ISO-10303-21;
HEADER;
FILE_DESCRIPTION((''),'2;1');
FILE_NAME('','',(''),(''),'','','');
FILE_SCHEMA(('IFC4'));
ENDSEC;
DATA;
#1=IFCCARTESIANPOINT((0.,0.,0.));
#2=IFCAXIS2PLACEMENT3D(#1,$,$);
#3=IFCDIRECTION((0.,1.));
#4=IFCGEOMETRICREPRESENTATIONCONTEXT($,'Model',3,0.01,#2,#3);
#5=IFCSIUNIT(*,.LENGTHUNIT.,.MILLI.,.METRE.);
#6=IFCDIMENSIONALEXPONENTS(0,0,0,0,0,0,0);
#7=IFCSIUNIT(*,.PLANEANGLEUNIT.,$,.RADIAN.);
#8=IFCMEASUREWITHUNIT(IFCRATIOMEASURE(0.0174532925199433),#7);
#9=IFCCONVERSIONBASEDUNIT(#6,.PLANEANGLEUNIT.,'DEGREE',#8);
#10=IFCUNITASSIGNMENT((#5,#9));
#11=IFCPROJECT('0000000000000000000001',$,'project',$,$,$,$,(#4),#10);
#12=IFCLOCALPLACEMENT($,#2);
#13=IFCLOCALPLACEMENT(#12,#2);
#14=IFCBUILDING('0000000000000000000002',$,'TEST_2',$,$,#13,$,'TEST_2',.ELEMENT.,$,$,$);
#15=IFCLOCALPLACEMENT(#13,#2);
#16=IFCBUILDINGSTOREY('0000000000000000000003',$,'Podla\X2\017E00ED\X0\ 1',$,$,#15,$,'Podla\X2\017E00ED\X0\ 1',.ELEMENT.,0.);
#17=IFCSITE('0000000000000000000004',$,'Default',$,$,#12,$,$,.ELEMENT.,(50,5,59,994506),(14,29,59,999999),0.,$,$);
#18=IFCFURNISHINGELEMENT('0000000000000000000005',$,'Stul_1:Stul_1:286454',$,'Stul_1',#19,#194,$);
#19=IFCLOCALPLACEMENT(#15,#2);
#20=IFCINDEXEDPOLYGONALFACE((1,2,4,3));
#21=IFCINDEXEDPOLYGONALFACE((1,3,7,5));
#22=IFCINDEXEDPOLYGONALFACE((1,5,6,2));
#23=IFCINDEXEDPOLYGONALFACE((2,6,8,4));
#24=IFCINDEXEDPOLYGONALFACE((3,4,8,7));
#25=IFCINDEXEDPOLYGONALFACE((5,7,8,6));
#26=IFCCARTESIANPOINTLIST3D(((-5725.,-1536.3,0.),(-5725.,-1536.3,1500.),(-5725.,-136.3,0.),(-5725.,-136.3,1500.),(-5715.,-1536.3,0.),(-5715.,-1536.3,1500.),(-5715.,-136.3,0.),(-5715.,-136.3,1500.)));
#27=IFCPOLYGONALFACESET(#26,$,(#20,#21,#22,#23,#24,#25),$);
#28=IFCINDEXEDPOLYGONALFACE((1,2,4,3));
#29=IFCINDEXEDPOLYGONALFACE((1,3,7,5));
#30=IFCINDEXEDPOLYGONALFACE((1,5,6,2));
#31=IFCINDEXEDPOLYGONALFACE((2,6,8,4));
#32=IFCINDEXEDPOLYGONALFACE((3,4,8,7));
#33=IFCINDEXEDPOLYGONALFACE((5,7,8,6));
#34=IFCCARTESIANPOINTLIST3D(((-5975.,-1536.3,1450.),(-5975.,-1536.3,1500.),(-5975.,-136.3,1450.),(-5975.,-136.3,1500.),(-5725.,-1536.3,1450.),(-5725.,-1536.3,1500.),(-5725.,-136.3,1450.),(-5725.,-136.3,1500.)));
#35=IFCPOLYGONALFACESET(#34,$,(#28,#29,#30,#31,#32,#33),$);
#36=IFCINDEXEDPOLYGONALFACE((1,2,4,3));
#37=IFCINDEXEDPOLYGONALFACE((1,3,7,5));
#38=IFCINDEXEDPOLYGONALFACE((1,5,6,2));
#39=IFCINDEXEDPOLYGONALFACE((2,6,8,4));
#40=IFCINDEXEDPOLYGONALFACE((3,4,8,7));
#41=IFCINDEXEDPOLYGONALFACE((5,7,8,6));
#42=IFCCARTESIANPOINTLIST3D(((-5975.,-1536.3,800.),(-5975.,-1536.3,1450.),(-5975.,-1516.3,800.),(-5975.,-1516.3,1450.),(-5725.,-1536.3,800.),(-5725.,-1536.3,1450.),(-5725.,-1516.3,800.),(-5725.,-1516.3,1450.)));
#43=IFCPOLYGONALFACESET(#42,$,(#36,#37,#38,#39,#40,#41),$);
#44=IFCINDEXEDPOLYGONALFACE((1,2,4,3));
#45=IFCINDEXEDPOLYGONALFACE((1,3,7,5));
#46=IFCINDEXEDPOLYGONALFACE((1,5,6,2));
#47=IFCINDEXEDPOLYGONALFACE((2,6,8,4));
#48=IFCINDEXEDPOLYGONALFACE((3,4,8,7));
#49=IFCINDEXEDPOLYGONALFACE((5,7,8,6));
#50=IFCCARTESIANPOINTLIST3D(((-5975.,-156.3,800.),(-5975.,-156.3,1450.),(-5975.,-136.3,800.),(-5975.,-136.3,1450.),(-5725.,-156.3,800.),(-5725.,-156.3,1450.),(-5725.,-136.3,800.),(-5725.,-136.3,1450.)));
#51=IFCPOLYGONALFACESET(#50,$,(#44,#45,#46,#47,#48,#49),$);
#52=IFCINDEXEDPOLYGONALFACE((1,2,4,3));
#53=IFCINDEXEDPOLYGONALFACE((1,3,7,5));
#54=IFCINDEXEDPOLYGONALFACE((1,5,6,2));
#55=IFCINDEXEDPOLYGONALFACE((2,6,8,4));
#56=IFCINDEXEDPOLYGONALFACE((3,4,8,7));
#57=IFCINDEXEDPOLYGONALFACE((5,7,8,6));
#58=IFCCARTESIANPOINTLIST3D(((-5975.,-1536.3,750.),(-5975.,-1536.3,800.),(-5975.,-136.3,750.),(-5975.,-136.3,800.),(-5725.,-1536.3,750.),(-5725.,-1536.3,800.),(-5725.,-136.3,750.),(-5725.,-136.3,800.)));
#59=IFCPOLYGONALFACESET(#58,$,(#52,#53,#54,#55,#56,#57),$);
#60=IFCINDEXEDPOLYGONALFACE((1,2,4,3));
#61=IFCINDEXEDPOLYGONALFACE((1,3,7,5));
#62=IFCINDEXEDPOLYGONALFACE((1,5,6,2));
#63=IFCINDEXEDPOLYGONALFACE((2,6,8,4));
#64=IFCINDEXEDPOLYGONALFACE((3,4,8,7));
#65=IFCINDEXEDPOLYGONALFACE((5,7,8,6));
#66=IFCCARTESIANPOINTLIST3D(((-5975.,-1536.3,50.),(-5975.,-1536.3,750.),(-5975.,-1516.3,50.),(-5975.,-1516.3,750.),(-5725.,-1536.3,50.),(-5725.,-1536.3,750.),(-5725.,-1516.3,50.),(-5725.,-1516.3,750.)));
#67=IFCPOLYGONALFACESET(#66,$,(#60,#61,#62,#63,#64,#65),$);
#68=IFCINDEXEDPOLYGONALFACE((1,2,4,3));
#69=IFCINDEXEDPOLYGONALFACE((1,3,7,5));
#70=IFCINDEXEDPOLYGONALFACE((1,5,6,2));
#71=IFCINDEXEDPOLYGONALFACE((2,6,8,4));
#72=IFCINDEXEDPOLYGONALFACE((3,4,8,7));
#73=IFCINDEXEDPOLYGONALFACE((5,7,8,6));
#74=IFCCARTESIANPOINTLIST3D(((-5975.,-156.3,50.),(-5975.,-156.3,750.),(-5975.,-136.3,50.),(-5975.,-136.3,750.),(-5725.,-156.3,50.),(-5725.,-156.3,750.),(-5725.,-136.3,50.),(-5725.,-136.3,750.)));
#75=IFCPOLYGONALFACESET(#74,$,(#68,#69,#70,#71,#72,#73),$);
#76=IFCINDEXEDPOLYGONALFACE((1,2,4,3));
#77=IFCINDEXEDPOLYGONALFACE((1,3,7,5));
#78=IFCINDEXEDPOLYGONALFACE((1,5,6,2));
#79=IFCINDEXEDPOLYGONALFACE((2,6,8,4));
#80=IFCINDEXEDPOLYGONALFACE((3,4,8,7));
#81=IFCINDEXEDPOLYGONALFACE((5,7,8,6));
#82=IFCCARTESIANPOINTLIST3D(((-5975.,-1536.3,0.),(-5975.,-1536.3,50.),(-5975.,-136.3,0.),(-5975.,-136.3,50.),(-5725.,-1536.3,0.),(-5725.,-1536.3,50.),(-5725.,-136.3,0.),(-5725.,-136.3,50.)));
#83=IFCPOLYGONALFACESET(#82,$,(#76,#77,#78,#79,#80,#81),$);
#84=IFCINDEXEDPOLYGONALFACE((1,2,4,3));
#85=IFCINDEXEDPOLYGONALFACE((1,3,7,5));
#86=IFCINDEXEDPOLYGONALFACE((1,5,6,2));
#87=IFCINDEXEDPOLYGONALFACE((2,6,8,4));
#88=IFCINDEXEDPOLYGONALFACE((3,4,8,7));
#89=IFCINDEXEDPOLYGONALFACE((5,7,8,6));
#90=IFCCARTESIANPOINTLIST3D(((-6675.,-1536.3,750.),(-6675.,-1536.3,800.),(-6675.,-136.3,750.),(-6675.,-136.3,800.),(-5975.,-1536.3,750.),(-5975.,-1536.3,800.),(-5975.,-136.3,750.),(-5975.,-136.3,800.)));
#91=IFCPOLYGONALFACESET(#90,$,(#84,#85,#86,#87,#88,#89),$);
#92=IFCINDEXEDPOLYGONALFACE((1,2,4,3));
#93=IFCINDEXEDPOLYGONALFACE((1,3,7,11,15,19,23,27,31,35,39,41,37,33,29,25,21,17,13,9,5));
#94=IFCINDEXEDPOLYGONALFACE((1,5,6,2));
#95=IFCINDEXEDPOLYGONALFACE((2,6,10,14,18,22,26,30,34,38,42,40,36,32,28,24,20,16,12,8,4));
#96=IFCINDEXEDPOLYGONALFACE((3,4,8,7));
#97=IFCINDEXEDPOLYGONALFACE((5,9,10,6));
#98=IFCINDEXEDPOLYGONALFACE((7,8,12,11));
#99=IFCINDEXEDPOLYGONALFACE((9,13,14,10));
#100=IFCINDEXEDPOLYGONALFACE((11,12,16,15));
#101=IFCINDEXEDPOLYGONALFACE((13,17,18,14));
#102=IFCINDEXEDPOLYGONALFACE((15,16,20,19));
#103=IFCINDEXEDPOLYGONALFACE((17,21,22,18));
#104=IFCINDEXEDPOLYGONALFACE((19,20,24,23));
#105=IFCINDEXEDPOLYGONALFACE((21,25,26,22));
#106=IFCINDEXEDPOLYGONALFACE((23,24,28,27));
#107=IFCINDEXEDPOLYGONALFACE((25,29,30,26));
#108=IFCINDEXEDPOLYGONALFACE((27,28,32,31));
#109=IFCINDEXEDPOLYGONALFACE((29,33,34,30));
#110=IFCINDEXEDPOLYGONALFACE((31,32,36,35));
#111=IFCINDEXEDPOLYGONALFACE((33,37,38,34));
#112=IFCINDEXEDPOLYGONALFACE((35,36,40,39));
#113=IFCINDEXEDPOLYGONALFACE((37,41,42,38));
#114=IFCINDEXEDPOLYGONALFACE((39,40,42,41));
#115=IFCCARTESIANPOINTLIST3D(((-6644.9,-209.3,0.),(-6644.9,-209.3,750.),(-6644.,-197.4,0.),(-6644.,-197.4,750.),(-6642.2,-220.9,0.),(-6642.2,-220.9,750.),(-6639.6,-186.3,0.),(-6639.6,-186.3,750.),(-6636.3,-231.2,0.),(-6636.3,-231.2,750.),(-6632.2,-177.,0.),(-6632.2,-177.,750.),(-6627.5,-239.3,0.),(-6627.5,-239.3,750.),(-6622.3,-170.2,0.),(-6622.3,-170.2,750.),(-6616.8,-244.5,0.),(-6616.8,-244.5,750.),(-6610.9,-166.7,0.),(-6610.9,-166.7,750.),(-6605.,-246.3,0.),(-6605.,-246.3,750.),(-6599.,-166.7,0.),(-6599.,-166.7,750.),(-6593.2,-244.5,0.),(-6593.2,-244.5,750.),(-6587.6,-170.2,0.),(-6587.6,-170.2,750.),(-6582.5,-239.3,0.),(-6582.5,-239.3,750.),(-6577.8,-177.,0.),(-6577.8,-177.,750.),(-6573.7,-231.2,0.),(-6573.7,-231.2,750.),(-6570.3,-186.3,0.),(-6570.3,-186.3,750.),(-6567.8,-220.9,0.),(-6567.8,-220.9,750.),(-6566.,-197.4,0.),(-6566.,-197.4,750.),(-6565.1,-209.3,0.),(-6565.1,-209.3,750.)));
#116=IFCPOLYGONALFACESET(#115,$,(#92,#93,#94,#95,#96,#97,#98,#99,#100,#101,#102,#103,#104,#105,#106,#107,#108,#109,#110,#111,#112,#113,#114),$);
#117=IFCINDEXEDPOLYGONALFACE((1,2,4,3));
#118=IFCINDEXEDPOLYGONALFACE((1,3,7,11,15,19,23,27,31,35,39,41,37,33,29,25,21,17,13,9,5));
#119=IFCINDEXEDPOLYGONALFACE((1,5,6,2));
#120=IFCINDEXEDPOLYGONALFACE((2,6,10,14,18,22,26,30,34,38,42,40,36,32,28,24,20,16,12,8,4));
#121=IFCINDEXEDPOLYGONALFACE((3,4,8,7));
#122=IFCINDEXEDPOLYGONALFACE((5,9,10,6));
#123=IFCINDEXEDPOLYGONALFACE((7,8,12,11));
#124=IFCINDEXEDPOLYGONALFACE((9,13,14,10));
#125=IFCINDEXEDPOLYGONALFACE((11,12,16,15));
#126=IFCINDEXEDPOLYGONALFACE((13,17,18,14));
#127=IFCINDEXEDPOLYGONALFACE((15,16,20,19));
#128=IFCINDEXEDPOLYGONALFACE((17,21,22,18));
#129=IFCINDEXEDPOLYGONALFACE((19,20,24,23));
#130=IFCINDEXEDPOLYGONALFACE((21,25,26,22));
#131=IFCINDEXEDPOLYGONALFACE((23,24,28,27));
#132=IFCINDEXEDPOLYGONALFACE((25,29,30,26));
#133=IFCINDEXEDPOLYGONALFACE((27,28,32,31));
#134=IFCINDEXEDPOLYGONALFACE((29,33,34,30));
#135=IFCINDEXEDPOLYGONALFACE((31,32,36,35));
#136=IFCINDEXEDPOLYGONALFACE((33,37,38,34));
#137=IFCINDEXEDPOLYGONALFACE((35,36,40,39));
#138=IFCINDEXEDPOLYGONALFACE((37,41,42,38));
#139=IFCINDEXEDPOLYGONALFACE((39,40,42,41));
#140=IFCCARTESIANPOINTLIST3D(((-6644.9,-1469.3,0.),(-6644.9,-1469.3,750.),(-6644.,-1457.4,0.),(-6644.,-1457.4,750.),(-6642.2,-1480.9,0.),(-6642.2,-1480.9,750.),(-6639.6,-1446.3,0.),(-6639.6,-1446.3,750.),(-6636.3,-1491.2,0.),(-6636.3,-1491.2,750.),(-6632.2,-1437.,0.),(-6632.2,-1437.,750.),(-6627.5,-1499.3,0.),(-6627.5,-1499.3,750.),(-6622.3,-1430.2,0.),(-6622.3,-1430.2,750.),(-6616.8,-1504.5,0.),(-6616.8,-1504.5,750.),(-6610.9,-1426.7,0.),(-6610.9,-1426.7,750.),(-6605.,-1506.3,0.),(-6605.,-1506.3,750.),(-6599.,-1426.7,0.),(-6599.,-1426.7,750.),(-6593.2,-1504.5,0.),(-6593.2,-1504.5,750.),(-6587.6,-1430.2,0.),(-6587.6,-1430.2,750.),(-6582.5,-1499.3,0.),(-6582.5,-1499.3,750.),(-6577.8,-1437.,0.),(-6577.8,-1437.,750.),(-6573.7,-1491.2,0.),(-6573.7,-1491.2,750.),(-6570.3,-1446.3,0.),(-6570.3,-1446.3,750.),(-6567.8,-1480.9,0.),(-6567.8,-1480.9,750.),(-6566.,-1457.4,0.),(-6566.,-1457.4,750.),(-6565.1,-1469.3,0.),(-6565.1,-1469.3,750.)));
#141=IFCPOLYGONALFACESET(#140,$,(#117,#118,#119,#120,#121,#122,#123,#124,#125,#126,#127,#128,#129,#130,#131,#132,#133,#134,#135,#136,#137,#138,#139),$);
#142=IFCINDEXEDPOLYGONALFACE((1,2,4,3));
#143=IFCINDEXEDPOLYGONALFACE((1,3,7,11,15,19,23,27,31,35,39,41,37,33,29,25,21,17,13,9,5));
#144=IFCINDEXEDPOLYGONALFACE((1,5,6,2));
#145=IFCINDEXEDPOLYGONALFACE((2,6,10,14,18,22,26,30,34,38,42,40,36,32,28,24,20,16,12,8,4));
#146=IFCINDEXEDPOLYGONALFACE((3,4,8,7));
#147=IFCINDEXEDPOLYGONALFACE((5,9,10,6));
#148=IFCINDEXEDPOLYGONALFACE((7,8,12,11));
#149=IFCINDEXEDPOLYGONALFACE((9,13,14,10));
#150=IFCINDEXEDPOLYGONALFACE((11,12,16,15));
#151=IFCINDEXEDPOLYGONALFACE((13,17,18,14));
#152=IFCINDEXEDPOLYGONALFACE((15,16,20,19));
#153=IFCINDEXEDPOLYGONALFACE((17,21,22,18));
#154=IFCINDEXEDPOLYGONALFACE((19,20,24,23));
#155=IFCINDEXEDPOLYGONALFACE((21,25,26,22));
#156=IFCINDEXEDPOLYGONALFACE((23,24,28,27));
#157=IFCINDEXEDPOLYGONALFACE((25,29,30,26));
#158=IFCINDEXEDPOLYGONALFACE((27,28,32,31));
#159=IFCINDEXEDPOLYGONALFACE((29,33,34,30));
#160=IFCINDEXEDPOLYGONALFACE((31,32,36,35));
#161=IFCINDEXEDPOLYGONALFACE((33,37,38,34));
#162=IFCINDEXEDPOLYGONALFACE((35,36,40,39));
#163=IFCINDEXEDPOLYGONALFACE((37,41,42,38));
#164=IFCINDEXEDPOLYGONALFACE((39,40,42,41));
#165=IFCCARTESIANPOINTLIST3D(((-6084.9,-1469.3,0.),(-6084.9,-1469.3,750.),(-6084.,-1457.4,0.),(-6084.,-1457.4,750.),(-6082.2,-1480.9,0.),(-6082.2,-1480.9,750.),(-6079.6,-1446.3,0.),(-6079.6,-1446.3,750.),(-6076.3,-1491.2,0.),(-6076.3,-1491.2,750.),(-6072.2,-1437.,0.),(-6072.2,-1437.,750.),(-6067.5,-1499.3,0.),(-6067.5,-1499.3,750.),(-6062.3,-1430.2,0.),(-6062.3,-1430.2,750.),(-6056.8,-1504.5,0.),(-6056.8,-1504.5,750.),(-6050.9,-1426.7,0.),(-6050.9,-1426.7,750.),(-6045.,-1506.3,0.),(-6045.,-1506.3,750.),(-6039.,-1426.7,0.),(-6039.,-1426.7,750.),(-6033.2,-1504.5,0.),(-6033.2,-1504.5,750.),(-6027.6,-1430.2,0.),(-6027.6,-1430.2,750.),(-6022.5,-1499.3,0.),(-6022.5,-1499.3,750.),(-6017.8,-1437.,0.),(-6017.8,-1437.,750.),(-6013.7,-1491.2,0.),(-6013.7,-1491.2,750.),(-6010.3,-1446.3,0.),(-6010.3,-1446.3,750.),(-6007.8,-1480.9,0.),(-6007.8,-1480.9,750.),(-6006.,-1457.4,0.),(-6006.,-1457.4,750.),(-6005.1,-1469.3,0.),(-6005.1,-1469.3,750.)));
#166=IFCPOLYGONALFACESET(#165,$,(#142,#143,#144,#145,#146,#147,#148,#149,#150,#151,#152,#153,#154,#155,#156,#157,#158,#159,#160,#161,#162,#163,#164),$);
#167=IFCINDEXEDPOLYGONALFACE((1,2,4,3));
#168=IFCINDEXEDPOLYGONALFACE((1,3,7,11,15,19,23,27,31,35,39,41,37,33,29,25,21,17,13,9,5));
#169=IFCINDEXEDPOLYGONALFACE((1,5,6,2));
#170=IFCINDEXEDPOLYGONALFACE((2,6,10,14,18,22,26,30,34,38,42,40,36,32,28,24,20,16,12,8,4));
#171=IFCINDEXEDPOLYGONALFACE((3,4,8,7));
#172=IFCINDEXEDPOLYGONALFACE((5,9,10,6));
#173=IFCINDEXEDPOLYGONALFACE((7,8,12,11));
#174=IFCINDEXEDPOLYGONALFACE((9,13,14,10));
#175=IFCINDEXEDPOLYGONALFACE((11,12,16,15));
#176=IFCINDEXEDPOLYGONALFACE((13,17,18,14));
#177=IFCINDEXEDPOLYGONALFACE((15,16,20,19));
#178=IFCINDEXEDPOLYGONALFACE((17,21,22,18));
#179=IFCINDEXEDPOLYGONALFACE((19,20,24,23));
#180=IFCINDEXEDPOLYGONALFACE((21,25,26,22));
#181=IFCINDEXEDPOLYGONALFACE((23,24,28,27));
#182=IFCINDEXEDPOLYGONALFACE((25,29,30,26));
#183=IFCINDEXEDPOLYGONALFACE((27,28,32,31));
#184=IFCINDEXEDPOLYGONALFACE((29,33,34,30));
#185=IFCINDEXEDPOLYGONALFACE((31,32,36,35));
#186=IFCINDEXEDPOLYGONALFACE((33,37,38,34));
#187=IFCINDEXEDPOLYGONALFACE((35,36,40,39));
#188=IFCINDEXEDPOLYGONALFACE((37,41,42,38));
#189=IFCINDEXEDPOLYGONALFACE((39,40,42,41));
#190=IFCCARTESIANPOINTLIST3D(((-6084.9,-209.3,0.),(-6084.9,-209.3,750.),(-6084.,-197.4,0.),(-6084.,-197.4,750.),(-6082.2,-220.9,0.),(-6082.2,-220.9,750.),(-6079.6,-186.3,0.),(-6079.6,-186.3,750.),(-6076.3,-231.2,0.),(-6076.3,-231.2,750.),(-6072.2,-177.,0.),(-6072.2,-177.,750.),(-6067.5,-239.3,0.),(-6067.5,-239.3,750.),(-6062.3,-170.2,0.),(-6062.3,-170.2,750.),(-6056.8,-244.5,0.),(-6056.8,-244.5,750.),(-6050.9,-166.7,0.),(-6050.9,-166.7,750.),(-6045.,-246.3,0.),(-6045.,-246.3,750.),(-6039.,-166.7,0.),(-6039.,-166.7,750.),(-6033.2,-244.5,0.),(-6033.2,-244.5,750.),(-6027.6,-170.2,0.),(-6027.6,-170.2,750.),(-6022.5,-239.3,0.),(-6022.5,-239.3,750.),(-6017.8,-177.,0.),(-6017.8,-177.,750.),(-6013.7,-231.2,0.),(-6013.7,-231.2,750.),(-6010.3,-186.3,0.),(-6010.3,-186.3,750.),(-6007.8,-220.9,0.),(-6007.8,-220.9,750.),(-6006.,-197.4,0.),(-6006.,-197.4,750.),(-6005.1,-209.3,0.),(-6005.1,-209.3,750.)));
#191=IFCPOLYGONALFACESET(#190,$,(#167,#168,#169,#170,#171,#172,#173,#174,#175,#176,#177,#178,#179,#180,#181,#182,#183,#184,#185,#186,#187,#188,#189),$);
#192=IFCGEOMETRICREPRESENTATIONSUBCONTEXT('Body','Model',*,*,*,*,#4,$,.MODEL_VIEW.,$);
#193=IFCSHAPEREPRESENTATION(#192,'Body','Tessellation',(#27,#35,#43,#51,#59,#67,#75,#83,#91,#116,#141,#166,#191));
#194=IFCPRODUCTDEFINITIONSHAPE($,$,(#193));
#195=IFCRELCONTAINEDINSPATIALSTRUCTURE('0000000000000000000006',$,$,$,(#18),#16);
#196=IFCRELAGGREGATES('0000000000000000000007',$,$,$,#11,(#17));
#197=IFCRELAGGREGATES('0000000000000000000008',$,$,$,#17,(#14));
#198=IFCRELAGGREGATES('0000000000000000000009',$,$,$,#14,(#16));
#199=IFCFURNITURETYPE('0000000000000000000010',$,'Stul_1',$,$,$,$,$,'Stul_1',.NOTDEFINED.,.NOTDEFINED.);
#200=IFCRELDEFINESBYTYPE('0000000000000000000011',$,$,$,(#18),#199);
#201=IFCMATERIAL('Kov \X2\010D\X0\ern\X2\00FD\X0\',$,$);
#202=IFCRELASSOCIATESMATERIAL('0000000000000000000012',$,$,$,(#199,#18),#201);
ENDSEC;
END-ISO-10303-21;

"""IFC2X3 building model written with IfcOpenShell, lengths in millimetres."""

from ifc_helpers import new_model, entity, si_unit, converted_unit, direction, frame, frame_2d, origin, origin_2d_with_axis, place, context, subcontext, project, spatial, rectangle, circle, extrude, source, transform, mapped, material, type_object, type_shapes, element, save


model = new_model("IFC2X3")

# Units and contexts
model_context = context("Model", 3, precision=0.01, world=origin(), true_north=direction((0.0, 1.0)))
body_context = subcontext(model_context, "Body", "Model", "MODEL_VIEW")
ifc_project = project(units=[si_unit("LENGTHUNIT", "METRE", prefix="MILLI"), converted_unit("PLANEANGLEUNIT", "DEGREE", entity("IfcRatioMeasure", 0.0174532925199433), si_unit("PLANEANGLEUNIT", "RADIAN"), dimensions=[0, 0, 0, 0, 0, 0, 0])], contexts=[model_context])

# Site, building, storey
site_placement = place(None, origin())
site = spatial("IfcSite", under=ifc_project, at=site_placement, Name="Default", CompositionType="ELEMENT", RefLatitude=(50, 5, 59, 994506), RefLongitude=(14, 29, 59, 999999), RefElevation=0.0)
building_placement = place(site_placement, origin())
building = spatial("IfcBuilding", under=site, at=building_placement, Name="TEST_2", LongName="TEST_2", CompositionType="ELEMENT")
storey_placement = place(building_placement, origin())
storey = spatial("IfcBuildingStorey", under=building, at=storey_placement, Name="Podlaží 1", LongName="Podlaží 1", CompositionType="ELEMENT", Elevation=0.0)

# Furnishing element
ifc_material_1 = material(Name="Kov černý")
furniture_type = type_object("IfcFurnitureType", Name="Stul_1", ElementType="Stul_1", material=ifc_material_1)
shared_shape_1 = source(origin(), body_context, "Body", "SweptSolid", [
    extrude(rectangle(XDim=1400.0, YDim=10.0, at=origin_2d_with_axis()), frame((0.0, 605.0, 0.0), z_axis=(0.0, 0.0, 1.0), x_axis=(-1.0, 0.0, 0.0)), (0.0, 0.0, 1.0), 1500.0),
    extrude(rectangle(XDim=1400.0, YDim=250.0, at=frame_2d((0.0, 0.0), x_axis=(1.0, 0.0))), frame((0.0, 475.0, 1450.0), z_axis=(0.0, 0.0, 1.0), x_axis=(-1.0, 0.0, 0.0)), (0.0, 0.0, 1.0), 50.0),
    extrude(rectangle(XDim=20.0, YDim=250.0, at=origin_2d_with_axis()), frame((690.0, 475.0, 800.0), z_axis=(0.0, 0.0, 1.0), x_axis=(-1.0, 0.0, 0.0)), (0.0, 0.0, 1.0), 650.0),
    extrude(rectangle(XDim=20.0, YDim=250.0, at=frame_2d((0.0, 0.0), x_axis=(1.0, 0.0))), frame((-690.0, 475.0, 800.0), z_axis=(0.0, 0.0, 1.0), x_axis=(-1.0, 0.0, 0.0)), (0.0, 0.0, 1.0), 650.0),
    extrude(rectangle(XDim=1400.0, YDim=250.0, at=origin_2d_with_axis()), frame((0.0, 475.0, 750.0), z_axis=(0.0, 0.0, 1.0), x_axis=(-1.0, 0.0, 0.0)), (0.0, 0.0, 1.0), 50.0),
    extrude(rectangle(XDim=20.0, YDim=250.0, at=origin_2d_with_axis()), frame((690.0, 475.0, 50.0), z_axis=(0.0, 0.0, 1.0), x_axis=(-1.0, 0.0, 0.0)), (0.0, 0.0, 1.0), 700.0),
    extrude(rectangle(XDim=20.0, YDim=250.0, at=frame_2d((0.0, 0.0), x_axis=(1.0, 0.0))), frame((-690.0, 475.0, 50.0), z_axis=(0.0, 0.0, 1.0), x_axis=(-1.0, 0.0, 0.0)), (0.0, 0.0, 1.0), 700.0),
    extrude(rectangle(XDim=1400.0, YDim=250.0, at=origin_2d_with_axis()), frame((0.0, 475.0, 0.0), z_axis=(0.0, 0.0, 1.0), x_axis=(-1.0, 0.0, 0.0)), (0.0, 0.0, 1.0), 50.0),
    extrude(rectangle(XDim=1400.0, YDim=700.0, at=origin_2d_with_axis()), frame((0.0, 0.0, 750.0), z_axis=(0.0, 0.0, 1.0), x_axis=(-1.0, 0.0, 0.0)), (0.0, 0.0, 1.0), 50.0),
    extrude(circle(Radius=40.0, at=frame_2d((0.0, 0.0), x_axis=(1.0, 0.0))), frame((-630.0, -280.0, 0.0)), (0.0, 0.0, 1.0), 750.0),
    extrude(circle(Radius=40.0, at=frame_2d((0.0, 0.0), x_axis=(1.0, 0.0))), frame((630.0, -280.0, 0.0)), (0.0, 0.0, 1.0), 750.0),
    extrude(circle(Radius=40.0, at=frame_2d((0.0, 0.0), x_axis=(1.0, 0.0))), frame((630.0, 280.0, 0.0)), (0.0, 0.0, 1.0), 750.0),
    extrude(circle(Radius=40.0, at=frame_2d((0.0, 0.0), x_axis=(1.0, 0.0))), frame((-630.0, 280.0, 0.0)), (0.0, 0.0, 1.0), 750.0),
])
type_shapes(furniture_type, [shared_shape_1])
for number, where, z_axis, x_axis, name in (
    (1, (-6325.0, -836.3, 0.0), (0.0, 0.0, 1.0), (0.0, -1.0, 0.0), "Stul_1:Stul_1:286454"),
):
    element("IfcFurnishingElement", number, at=place(storey_placement, frame(where, z_axis=z_axis, x_axis=x_axis)), inside=storey, type_object=furniture_type, material=ifc_material_1, Name=name, ObjectType="Stul_1", context=body_context, shape_type="MappedRepresentation", body=[
        mapped(shared_shape_1, transform((0.0, 0.0, 0.0), scale=1.0)),
    ])

save(model, "model.ifc")
